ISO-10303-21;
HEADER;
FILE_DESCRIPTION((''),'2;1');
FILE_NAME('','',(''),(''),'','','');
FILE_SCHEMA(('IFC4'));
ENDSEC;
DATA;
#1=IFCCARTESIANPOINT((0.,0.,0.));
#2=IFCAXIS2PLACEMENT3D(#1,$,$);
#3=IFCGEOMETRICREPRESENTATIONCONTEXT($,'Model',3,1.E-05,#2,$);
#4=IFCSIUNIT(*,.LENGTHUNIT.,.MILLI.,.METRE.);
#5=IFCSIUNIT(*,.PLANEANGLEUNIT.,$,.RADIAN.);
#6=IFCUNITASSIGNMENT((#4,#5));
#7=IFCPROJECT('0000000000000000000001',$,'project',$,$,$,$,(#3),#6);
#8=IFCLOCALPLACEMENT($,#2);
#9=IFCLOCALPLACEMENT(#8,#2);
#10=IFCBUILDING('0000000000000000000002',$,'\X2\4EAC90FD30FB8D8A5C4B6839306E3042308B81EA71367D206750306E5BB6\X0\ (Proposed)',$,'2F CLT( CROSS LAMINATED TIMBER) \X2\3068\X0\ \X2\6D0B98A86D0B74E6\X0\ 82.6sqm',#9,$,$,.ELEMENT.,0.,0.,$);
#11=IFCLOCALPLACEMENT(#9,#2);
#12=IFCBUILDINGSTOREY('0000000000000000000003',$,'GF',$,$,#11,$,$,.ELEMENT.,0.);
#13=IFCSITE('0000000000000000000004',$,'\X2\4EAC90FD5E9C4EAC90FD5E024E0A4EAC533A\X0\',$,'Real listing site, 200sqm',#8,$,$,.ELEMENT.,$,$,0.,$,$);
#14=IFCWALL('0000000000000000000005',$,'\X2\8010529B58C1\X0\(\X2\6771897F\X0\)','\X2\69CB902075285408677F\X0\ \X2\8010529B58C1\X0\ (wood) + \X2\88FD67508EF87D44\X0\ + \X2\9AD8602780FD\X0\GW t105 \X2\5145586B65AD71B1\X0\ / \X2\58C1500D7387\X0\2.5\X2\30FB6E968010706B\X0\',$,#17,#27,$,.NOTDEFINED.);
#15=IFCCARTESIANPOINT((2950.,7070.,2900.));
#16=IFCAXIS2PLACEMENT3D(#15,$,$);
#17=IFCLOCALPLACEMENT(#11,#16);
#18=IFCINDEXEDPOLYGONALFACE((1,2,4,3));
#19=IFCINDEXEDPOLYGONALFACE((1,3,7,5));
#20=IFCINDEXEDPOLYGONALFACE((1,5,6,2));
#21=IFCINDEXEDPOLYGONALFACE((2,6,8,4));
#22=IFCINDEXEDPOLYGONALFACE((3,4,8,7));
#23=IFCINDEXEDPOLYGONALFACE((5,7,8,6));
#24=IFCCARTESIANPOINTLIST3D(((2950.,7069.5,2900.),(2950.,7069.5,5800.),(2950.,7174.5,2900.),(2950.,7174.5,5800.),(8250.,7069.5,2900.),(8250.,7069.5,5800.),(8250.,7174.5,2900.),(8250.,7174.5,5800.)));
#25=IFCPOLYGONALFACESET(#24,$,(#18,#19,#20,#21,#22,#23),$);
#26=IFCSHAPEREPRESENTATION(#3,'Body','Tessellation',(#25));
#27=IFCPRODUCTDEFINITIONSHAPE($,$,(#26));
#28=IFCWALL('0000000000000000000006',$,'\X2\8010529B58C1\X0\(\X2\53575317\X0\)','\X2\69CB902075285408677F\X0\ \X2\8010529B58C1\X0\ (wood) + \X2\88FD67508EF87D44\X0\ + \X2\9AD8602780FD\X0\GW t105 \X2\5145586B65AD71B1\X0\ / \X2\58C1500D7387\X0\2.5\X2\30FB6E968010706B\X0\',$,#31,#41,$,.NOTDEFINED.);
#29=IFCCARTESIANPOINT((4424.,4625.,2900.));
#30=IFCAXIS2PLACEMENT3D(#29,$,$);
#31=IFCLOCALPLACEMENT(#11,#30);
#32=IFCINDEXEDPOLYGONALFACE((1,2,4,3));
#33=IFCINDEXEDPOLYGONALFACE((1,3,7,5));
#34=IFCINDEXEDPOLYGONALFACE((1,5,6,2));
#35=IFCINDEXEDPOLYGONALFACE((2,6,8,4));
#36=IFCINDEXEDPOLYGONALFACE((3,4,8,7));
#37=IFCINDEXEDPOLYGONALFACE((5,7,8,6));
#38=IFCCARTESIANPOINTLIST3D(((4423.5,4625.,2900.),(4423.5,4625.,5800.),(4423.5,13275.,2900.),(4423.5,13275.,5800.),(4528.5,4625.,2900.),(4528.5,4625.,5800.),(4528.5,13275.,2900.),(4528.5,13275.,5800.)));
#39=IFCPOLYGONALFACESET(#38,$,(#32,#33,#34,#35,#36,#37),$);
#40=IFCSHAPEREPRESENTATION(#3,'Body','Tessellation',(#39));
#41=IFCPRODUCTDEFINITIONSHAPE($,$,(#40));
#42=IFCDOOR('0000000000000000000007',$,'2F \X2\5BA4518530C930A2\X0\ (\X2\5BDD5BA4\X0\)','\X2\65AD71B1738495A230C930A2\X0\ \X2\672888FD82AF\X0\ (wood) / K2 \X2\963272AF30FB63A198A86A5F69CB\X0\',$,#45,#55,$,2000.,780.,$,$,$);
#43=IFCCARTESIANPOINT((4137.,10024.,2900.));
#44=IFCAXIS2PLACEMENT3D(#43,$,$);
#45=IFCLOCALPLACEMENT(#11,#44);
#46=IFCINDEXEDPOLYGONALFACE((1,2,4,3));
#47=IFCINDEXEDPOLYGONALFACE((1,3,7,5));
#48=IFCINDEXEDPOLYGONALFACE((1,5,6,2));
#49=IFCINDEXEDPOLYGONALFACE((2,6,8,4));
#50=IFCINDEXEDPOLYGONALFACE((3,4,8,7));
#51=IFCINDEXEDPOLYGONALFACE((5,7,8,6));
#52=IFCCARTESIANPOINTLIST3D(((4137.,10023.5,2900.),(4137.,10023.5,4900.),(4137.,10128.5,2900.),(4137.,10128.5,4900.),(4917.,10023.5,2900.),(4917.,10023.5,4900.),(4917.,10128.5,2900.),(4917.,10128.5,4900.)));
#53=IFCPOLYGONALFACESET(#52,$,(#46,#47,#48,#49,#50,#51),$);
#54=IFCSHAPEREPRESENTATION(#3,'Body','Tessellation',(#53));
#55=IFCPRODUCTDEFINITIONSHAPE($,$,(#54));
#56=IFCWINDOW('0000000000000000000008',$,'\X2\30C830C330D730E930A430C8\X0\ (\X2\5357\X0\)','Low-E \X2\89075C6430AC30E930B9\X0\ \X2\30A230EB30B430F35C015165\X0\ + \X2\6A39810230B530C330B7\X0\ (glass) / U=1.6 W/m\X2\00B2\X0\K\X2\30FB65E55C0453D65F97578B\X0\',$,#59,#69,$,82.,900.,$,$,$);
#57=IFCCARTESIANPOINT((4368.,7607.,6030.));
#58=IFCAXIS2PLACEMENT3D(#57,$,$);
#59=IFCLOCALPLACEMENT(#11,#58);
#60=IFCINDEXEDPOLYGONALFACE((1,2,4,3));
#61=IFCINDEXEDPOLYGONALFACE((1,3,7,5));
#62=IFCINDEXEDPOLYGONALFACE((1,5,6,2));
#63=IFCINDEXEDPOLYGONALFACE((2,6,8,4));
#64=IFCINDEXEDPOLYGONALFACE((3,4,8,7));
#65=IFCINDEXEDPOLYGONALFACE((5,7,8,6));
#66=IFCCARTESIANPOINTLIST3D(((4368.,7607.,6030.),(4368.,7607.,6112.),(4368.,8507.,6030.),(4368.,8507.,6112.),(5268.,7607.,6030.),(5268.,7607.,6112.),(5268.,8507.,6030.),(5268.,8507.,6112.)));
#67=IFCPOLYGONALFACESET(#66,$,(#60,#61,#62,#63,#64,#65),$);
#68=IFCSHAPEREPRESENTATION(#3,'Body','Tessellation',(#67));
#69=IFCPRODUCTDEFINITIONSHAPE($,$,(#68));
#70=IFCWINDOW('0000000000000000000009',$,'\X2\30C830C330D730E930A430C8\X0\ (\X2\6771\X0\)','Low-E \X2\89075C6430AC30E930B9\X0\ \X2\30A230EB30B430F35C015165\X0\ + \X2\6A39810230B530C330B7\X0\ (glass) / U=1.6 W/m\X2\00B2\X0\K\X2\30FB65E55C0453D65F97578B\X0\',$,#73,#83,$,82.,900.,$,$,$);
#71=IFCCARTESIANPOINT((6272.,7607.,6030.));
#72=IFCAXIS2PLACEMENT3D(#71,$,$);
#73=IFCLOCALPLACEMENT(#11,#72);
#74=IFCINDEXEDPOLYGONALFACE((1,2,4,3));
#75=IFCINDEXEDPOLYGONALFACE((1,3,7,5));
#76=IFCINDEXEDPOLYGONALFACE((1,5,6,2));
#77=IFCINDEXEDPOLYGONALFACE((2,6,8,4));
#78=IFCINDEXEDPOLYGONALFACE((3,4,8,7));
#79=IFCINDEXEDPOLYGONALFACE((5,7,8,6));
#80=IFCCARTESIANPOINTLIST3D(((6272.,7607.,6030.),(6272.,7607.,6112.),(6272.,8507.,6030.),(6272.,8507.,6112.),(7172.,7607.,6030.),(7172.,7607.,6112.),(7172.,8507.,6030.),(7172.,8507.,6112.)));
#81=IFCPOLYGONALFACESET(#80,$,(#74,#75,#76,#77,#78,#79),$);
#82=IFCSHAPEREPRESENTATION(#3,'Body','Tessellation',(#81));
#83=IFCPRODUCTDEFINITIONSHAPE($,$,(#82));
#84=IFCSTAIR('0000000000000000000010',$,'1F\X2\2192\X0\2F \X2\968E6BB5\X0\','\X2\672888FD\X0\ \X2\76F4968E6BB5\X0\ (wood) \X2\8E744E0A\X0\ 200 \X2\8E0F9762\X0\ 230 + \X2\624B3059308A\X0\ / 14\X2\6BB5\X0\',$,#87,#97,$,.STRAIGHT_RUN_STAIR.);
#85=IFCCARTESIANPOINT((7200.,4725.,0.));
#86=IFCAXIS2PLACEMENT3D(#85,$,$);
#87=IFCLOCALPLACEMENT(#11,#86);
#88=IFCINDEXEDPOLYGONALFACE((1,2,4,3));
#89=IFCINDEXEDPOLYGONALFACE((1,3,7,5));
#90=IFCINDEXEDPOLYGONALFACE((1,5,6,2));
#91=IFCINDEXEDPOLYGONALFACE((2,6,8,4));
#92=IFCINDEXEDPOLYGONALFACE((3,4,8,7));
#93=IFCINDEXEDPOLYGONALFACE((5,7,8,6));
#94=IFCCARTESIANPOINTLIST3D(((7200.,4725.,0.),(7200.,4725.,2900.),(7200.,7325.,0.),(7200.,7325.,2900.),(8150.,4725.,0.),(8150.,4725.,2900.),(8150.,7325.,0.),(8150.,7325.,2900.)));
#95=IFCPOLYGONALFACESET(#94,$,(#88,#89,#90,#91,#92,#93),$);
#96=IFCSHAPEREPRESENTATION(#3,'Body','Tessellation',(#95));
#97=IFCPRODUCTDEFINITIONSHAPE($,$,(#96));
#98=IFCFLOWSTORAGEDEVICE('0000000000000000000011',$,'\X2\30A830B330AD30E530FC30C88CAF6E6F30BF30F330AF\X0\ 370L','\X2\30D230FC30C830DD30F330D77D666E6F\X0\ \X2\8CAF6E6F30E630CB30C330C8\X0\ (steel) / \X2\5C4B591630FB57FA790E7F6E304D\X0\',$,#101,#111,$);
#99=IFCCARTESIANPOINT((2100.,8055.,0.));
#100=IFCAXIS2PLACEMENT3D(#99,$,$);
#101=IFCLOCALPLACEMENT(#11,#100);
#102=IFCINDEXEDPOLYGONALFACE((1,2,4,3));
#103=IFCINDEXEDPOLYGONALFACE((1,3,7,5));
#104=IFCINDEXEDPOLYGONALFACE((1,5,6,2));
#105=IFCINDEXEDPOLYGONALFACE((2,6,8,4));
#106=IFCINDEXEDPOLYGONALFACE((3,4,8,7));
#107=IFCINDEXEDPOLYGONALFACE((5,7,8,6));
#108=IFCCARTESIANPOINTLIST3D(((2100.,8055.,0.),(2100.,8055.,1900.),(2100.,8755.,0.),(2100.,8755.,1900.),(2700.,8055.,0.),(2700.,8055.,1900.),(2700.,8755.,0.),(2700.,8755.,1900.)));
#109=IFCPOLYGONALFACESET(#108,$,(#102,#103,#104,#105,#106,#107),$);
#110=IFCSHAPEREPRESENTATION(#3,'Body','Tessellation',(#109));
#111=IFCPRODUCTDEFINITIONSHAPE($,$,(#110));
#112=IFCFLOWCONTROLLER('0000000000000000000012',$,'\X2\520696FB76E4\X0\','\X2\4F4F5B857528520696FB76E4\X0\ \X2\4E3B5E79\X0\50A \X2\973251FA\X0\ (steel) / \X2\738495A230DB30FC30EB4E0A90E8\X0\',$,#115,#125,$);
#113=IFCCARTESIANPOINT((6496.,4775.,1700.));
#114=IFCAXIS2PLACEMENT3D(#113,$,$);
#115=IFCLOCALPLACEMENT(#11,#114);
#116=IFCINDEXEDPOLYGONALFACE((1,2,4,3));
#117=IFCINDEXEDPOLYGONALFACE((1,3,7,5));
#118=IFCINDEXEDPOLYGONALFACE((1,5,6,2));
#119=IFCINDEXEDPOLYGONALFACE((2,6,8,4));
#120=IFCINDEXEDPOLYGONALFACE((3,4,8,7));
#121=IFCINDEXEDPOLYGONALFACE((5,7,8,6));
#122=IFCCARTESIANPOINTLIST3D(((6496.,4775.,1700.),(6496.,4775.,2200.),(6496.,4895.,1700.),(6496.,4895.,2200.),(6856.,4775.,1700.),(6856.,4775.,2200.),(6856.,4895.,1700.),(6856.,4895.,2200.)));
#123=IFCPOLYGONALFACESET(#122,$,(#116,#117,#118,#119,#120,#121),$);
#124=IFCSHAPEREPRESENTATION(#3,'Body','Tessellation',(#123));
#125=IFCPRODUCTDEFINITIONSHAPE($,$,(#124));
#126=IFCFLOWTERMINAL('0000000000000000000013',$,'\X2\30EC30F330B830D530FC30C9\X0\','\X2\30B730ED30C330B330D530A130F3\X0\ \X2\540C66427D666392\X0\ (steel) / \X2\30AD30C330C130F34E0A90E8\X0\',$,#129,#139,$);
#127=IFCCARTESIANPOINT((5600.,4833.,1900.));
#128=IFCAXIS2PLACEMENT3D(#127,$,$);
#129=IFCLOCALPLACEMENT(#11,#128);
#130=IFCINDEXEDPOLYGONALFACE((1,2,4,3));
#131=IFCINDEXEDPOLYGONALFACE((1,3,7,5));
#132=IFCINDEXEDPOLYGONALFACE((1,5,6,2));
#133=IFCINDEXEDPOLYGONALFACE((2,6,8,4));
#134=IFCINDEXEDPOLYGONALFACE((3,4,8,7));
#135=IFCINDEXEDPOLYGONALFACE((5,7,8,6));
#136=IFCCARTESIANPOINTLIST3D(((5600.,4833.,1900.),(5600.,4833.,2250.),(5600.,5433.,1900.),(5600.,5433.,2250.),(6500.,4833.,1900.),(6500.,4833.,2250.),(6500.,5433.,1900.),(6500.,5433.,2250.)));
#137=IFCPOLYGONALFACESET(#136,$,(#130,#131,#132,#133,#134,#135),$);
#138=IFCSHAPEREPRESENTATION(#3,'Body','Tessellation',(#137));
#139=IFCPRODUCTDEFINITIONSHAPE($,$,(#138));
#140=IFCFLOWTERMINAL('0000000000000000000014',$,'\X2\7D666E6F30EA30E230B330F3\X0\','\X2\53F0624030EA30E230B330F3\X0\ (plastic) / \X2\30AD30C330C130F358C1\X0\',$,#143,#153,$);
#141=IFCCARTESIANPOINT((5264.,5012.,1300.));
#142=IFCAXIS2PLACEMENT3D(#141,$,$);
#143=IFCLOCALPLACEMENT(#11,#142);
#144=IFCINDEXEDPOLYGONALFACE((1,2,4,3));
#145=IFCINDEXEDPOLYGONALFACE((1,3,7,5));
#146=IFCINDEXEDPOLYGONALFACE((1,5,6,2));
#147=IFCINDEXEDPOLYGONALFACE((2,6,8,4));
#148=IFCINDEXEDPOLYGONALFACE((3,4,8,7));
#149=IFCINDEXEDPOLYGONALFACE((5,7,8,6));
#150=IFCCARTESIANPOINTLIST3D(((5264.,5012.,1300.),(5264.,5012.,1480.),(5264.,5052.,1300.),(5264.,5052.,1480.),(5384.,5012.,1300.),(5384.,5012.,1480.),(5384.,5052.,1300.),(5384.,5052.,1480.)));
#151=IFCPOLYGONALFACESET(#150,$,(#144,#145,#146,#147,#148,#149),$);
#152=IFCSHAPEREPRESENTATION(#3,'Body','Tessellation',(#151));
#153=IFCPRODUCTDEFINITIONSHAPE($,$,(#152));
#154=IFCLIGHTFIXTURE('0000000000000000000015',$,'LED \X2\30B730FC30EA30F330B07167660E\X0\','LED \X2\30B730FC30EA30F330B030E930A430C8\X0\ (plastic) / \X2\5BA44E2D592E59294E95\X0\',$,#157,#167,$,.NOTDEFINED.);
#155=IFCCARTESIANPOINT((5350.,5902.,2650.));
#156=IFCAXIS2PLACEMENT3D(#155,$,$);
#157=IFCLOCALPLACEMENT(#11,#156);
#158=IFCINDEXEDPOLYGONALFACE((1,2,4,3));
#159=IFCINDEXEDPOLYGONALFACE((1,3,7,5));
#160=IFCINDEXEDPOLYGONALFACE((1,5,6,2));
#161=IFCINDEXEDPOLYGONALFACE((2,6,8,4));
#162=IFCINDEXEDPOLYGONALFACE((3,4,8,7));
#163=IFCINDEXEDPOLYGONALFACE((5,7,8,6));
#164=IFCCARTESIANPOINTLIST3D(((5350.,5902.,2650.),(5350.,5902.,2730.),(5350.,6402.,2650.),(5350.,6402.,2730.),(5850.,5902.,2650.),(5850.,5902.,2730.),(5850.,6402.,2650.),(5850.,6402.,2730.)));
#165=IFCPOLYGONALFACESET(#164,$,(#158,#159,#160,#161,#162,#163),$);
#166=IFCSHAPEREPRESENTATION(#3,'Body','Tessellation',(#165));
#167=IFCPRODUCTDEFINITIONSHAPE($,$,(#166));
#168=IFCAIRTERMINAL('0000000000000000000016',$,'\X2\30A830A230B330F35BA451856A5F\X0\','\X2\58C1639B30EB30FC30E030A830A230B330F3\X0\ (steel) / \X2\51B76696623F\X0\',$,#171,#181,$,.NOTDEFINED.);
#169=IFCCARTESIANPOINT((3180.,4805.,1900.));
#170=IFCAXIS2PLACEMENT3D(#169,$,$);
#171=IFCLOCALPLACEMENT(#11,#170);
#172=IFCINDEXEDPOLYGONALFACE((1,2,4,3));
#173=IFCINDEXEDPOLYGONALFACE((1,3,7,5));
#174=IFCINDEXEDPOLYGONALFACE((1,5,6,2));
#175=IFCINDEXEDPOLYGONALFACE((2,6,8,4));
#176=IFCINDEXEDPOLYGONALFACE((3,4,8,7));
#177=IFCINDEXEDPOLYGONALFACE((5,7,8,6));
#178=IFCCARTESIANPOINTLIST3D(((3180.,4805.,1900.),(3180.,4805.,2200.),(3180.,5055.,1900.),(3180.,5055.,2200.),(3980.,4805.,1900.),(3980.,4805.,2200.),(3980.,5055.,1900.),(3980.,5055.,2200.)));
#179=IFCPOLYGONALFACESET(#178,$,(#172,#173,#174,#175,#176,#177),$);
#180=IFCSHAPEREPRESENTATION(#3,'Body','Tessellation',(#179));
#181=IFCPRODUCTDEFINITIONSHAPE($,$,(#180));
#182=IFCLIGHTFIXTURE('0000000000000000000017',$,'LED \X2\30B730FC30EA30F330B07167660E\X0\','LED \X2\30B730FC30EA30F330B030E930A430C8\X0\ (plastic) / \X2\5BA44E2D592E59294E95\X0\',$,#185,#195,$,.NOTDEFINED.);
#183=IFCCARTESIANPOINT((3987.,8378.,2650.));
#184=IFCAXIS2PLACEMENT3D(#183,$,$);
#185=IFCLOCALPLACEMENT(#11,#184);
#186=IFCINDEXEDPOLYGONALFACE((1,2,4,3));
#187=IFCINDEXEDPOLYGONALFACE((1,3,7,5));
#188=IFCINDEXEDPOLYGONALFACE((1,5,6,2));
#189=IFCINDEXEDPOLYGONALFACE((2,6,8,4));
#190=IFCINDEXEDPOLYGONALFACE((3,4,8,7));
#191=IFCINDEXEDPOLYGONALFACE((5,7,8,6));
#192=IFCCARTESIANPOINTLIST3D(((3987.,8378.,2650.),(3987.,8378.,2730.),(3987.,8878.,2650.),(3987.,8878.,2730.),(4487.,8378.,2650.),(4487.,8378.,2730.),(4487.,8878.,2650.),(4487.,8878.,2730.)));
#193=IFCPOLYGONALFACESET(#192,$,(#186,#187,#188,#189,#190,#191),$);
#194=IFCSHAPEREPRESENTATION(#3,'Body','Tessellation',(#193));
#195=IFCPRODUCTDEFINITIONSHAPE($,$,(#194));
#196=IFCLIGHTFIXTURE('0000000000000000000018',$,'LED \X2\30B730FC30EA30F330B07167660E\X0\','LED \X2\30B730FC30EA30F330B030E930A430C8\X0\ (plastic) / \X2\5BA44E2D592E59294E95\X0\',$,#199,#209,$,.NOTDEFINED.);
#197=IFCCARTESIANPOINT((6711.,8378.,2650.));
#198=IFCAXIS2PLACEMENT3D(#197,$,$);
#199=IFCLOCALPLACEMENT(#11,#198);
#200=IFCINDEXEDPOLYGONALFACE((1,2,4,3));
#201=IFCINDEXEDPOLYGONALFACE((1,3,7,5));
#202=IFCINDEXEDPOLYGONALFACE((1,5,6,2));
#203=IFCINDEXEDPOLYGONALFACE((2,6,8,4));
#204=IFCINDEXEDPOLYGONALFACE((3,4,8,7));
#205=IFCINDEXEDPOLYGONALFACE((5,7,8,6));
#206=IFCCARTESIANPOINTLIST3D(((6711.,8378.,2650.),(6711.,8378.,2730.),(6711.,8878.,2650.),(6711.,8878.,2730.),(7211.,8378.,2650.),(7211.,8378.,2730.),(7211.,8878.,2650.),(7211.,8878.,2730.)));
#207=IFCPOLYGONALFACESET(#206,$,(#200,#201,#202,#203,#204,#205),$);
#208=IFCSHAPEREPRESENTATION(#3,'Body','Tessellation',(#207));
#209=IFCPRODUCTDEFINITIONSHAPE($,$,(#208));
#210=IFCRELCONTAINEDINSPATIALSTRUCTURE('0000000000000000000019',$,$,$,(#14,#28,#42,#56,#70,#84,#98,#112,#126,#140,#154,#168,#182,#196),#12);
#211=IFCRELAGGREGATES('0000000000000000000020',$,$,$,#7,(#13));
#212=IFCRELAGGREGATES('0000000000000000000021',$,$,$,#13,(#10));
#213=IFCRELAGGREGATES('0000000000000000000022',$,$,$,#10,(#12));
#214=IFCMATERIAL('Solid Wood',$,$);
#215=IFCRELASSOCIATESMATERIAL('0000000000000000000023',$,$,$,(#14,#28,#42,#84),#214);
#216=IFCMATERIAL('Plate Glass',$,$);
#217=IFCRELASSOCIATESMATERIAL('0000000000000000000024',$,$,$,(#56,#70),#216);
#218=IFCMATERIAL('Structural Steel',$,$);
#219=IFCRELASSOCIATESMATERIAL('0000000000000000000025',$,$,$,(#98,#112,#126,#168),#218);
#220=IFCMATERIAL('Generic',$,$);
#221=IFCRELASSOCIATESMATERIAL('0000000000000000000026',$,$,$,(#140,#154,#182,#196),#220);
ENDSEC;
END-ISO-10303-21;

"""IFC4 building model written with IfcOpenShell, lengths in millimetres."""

from ifc_helpers import new_model, si_unit, frame, frame_2d, origin, place, context, project, spatial, rectangle, extrude, material, element, fill, save


model = new_model("IFC4")

# Units and contexts
model_context = context("Model", 3, precision=1e-05, world=origin())
ifc_project = project(units=[si_unit("LENGTHUNIT", "METRE", prefix="MILLI"), si_unit("PLANEANGLEUNIT", "RADIAN")], contexts=[model_context])

# Site, building, storey
site_placement = place(None, origin())
site = spatial("IfcSite", under=ifc_project, at=site_placement, Name="京都府京都市上京区", ObjectType="Real listing site, 200sqm", CompositionType="ELEMENT", RefElevation=0.0)
building_placement = place(site_placement, origin())
building = spatial("IfcBuilding", under=site, at=building_placement, Name="京都・越屋根のある自然素材の家 (Proposed)", ObjectType="2F CLT( CROSS LAMINATED TIMBER) と 洋風洋瓦 82.6sqm", CompositionType="ELEMENT", ElevationOfRefHeight=0.0, ElevationOfTerrain=0.0)
storey_placement = place(building_placement, origin())
storey = spatial("IfcBuildingStorey", under=building, at=storey_placement, Name="GF", CompositionType="ELEMENT", Elevation=0.0)

# Shared definitions
ifc_material_1 = material(Name="Solid Wood")

# Wall
wall_1_placement = place(storey_placement, frame((2950.0, 7070.0, 2900.0)))
element("IfcWall", 1, at=wall_1_placement, inside=storey, material=ifc_material_1, Name="耐力壁(東西)", Description="構造用合板 耐力壁 (wood) + 製材軸組 + 高性能GW t105 充填断熱 / 壁倍率2.5・準耐火", PredefinedType="NOTDEFINED", context=model_context, shape_type="SweptSolid", body=[
    extrude(rectangle(XDim=5300.0, YDim=105.0, at=frame_2d((2650.0, 52.0))), frame((2950.0, 7070.0, 2900.0)), (0.0, 0.0, 1.0), 2900.0),
])

# Wall, opening, door
wall_2_placement = place(storey_placement, frame((4424.0, 4625.0, 2900.0)))
wall_2 = element("IfcWall", 2, at=wall_2_placement, inside=storey, material=ifc_material_1, Name="耐力壁(南北)", Description="構造用合板 耐力壁 (wood) + 製材軸組 + 高性能GW t105 充填断熱 / 壁倍率2.5・準耐火", PredefinedType="NOTDEFINED", context=model_context, shape_type="SweptSolid", body=[
    extrude(rectangle(XDim=105.0, YDim=8650.0, at=frame_2d((52.0, 4325.0))), frame((4424.0, 4625.0, 2900.0)), (0.0, 0.0, 1.0), 2900.0),
])
opening_placement = place(storey_placement, frame((4137.0, 10024.0, 2900.0)))
opening = element("IfcOpeningElement", 3, at=opening_placement, cuts=wall_2, PredefinedType="NOTDEFINED", context=model_context, shape_type="SweptSolid", body=[
    extrude(rectangle(XDim=780.0, YDim=105.0, at=frame_2d((390.0, 52.0))), frame((4137.0, 10024.0, 2900.0)), (0.0, 0.0, 1.0), 2000.0),
])
door_placement = place(storey_placement, frame((4137.0, 10024.0, 2900.0)))
door = element("IfcDoor", 4, at=door_placement, inside=storey, material=ifc_material_1, Name="2F 室内ドア (寝室)", Description="断熱玄関ドア 木製芯 (wood) / K2 防犯・採風機構", OverallHeight=2000.0, OverallWidth=780.0, context=model_context, shape_type="SweptSolid", body=[
    extrude(rectangle(XDim=780.0, YDim=105.0, at=frame_2d((390.0, 52.0))), frame((4137.0, 10024.0, 2900.0)), (0.0, 0.0, 1.0), 2000.0),
])
fill(opening, door)

# Windows
ifc_material_2 = material(Name="Plate Glass")
window_1_placement = place(storey_placement, frame((4368.0, 7607.0, 6030.0)))
element("IfcWindow", 5, at=window_1_placement, inside=storey, material=ifc_material_2, Name="トップライト (南)", Description="Low-E 複層ガラス アルゴン封入 + 樹脂サッシ (glass) / U=1.6 W/m²K・日射取得型", OverallHeight=82.0, OverallWidth=900.0, context=model_context, shape_type="SweptSolid", body=[
    extrude(rectangle(XDim=900.0, YDim=900.0, at=frame_2d((450.0, 450.0))), frame((4368.0, 7607.0, 6030.0)), (0.0, 0.0, 1.0), 82.0),
])
window_2_placement = place(storey_placement, frame((6272.0, 7607.0, 6030.0)))
element("IfcWindow", 6, at=window_2_placement, inside=storey, material=ifc_material_2, Name="トップライト (東)", Description="Low-E 複層ガラス アルゴン封入 + 樹脂サッシ (glass) / U=1.6 W/m²K・日射取得型", OverallHeight=82.0, OverallWidth=900.0, context=model_context, shape_type="SweptSolid", body=[
    extrude(rectangle(XDim=900.0, YDim=900.0, at=frame_2d((450.0, 450.0))), frame((6272.0, 7607.0, 6030.0)), (0.0, 0.0, 1.0), 82.0),
])

# Stair
stair_placement = place(storey_placement, frame((7200.0, 4725.0, 0.0)))
element("IfcStair", 7, at=stair_placement, inside=storey, material=ifc_material_1, Name="1F→2F 階段", Description="木製 直階段 (wood) 蹴上 200 踏面 230 + 手すり / 14段", PredefinedType="STRAIGHT_RUN_STAIR", context=model_context, shape_type="SweptSolid", body=[
    extrude(rectangle(XDim=950.0, YDim=2600.0, at=frame_2d((475.0, 1300.0))), frame((7200.0, 4725.0, 0.0)), (0.0, 0.0, 1.0), 2900.0),
])

# Flow storage device
ifc_material_3 = material(Name="Structural Steel")
flow_storage_device_placement = place(storey_placement, frame((2100.0, 8055.0, 0.0)))
element("IfcFlowStorageDevice", 8, at=flow_storage_device_placement, inside=storey, material=ifc_material_3, Name="エコキュート貯湯タンク 370L", Description="ヒートポンプ給湯 貯湯ユニット (steel) / 屋外・基礎置き", context=model_context, shape_type="SweptSolid", body=[
    extrude(rectangle(XDim=600.0, YDim=700.0, at=frame_2d((300.0, 350.0))), frame((2100.0, 8055.0, 0.0)), (0.0, 0.0, 1.0), 1900.0),
])

# Flow controller
flow_controller_placement = place(storey_placement, frame((6496.0, 4775.0, 1700.0)))
element("IfcFlowController", 9, at=flow_controller_placement, inside=storey, material=ifc_material_3, Name="分電盤", Description="住宅用分電盤 主幹50A 露出 (steel) / 玄関ホール上部", context=model_context, shape_type="SweptSolid", body=[
    extrude(rectangle(XDim=360.0, YDim=120.0, at=frame_2d((180.0, 60.0))), frame((6496.0, 4775.0, 1700.0)), (0.0, 0.0, 1.0), 500.0),
])

# Flow terminals
flow_terminal_1_placement = place(storey_placement, frame((5600.0, 4833.0, 1900.0)))
element("IfcFlowTerminal", 10, at=flow_terminal_1_placement, inside=storey, material=ifc_material_3, Name="レンジフード", Description="シロッコファン 同時給排 (steel) / キッチン上部", context=model_context, shape_type="SweptSolid", body=[
    extrude(rectangle(XDim=900.0, YDim=600.0, at=frame_2d((450.0, 300.0))), frame((5600.0, 4833.0, 1900.0)), (0.0, 0.0, 1.0), 350.0),
])
ifc_material_4 = material(Name="Generic")
flow_terminal_2_placement = place(storey_placement, frame((5264.0, 5012.0, 1300.0)))
element("IfcFlowTerminal", 11, at=flow_terminal_2_placement, inside=storey, material=ifc_material_4, Name="給湯リモコン", Description="台所リモコン (plastic) / キッチン壁", context=model_context, shape_type="SweptSolid", body=[
    extrude(rectangle(XDim=120.0, YDim=40.0, at=frame_2d((60.0, 20.0))), frame((5264.0, 5012.0, 1300.0)), (0.0, 0.0, 1.0), 180.0),
])

# Light fixture
light_fixture_1_placement = place(storey_placement, frame((5350.0, 5902.0, 2650.0)))
element("IfcLightFixture", 12, at=light_fixture_1_placement, inside=storey, material=ifc_material_4, Name="LED シーリング照明", Description="LED シーリングライト (plastic) / 室中央天井", PredefinedType="NOTDEFINED", context=model_context, shape_type="SweptSolid", body=[
    extrude(rectangle(XDim=500.0, YDim=500.0, at=frame_2d((250.0, 250.0))), frame((5350.0, 5902.0, 2650.0)), (0.0, 0.0, 1.0), 80.0),
])

# Air terminal
air_terminal_1_placement = place(storey_placement, frame((3180.0, 4805.0, 1900.0)))
element("IfcAirTerminal", 13, at=air_terminal_1_placement, inside=storey, material=ifc_material_3, Name="エアコン室内機", Description="壁掛ルームエアコン (steel) / 冷暖房", PredefinedType="NOTDEFINED", context=model_context, shape_type="SweptSolid", body=[
    extrude(rectangle(XDim=800.0, YDim=250.0, at=frame_2d((400.0, 125.0))), frame((3180.0, 4805.0, 1900.0)), (0.0, 0.0, 1.0), 300.0),
])

# Light fixtures
light_fixture_2_placement = place(storey_placement, frame((3987.0, 8378.0, 2650.0)))
element("IfcLightFixture", 14, at=light_fixture_2_placement, inside=storey, material=ifc_material_4, Name="LED シーリング照明", Description="LED シーリングライト (plastic) / 室中央天井", PredefinedType="NOTDEFINED", context=model_context, shape_type="SweptSolid", body=[
    extrude(rectangle(XDim=500.0, YDim=500.0, at=frame_2d((250.0, 250.0))), frame((3987.0, 8378.0, 2650.0)), (0.0, 0.0, 1.0), 80.0),
])
light_fixture_3_placement = place(storey_placement, frame((6711.0, 8378.0, 2650.0)))
element("IfcLightFixture", 15, at=light_fixture_3_placement, inside=storey, material=ifc_material_4, Name="LED シーリング照明", Description="LED シーリングライト (plastic) / 室中央天井", PredefinedType="NOTDEFINED", context=model_context, shape_type="SweptSolid", body=[
    extrude(rectangle(XDim=500.0, YDim=500.0, at=frame_2d((250.0, 250.0))), frame((6711.0, 8378.0, 2650.0)), (0.0, 0.0, 1.0), 80.0),
])

save(model, "model.ifc")
